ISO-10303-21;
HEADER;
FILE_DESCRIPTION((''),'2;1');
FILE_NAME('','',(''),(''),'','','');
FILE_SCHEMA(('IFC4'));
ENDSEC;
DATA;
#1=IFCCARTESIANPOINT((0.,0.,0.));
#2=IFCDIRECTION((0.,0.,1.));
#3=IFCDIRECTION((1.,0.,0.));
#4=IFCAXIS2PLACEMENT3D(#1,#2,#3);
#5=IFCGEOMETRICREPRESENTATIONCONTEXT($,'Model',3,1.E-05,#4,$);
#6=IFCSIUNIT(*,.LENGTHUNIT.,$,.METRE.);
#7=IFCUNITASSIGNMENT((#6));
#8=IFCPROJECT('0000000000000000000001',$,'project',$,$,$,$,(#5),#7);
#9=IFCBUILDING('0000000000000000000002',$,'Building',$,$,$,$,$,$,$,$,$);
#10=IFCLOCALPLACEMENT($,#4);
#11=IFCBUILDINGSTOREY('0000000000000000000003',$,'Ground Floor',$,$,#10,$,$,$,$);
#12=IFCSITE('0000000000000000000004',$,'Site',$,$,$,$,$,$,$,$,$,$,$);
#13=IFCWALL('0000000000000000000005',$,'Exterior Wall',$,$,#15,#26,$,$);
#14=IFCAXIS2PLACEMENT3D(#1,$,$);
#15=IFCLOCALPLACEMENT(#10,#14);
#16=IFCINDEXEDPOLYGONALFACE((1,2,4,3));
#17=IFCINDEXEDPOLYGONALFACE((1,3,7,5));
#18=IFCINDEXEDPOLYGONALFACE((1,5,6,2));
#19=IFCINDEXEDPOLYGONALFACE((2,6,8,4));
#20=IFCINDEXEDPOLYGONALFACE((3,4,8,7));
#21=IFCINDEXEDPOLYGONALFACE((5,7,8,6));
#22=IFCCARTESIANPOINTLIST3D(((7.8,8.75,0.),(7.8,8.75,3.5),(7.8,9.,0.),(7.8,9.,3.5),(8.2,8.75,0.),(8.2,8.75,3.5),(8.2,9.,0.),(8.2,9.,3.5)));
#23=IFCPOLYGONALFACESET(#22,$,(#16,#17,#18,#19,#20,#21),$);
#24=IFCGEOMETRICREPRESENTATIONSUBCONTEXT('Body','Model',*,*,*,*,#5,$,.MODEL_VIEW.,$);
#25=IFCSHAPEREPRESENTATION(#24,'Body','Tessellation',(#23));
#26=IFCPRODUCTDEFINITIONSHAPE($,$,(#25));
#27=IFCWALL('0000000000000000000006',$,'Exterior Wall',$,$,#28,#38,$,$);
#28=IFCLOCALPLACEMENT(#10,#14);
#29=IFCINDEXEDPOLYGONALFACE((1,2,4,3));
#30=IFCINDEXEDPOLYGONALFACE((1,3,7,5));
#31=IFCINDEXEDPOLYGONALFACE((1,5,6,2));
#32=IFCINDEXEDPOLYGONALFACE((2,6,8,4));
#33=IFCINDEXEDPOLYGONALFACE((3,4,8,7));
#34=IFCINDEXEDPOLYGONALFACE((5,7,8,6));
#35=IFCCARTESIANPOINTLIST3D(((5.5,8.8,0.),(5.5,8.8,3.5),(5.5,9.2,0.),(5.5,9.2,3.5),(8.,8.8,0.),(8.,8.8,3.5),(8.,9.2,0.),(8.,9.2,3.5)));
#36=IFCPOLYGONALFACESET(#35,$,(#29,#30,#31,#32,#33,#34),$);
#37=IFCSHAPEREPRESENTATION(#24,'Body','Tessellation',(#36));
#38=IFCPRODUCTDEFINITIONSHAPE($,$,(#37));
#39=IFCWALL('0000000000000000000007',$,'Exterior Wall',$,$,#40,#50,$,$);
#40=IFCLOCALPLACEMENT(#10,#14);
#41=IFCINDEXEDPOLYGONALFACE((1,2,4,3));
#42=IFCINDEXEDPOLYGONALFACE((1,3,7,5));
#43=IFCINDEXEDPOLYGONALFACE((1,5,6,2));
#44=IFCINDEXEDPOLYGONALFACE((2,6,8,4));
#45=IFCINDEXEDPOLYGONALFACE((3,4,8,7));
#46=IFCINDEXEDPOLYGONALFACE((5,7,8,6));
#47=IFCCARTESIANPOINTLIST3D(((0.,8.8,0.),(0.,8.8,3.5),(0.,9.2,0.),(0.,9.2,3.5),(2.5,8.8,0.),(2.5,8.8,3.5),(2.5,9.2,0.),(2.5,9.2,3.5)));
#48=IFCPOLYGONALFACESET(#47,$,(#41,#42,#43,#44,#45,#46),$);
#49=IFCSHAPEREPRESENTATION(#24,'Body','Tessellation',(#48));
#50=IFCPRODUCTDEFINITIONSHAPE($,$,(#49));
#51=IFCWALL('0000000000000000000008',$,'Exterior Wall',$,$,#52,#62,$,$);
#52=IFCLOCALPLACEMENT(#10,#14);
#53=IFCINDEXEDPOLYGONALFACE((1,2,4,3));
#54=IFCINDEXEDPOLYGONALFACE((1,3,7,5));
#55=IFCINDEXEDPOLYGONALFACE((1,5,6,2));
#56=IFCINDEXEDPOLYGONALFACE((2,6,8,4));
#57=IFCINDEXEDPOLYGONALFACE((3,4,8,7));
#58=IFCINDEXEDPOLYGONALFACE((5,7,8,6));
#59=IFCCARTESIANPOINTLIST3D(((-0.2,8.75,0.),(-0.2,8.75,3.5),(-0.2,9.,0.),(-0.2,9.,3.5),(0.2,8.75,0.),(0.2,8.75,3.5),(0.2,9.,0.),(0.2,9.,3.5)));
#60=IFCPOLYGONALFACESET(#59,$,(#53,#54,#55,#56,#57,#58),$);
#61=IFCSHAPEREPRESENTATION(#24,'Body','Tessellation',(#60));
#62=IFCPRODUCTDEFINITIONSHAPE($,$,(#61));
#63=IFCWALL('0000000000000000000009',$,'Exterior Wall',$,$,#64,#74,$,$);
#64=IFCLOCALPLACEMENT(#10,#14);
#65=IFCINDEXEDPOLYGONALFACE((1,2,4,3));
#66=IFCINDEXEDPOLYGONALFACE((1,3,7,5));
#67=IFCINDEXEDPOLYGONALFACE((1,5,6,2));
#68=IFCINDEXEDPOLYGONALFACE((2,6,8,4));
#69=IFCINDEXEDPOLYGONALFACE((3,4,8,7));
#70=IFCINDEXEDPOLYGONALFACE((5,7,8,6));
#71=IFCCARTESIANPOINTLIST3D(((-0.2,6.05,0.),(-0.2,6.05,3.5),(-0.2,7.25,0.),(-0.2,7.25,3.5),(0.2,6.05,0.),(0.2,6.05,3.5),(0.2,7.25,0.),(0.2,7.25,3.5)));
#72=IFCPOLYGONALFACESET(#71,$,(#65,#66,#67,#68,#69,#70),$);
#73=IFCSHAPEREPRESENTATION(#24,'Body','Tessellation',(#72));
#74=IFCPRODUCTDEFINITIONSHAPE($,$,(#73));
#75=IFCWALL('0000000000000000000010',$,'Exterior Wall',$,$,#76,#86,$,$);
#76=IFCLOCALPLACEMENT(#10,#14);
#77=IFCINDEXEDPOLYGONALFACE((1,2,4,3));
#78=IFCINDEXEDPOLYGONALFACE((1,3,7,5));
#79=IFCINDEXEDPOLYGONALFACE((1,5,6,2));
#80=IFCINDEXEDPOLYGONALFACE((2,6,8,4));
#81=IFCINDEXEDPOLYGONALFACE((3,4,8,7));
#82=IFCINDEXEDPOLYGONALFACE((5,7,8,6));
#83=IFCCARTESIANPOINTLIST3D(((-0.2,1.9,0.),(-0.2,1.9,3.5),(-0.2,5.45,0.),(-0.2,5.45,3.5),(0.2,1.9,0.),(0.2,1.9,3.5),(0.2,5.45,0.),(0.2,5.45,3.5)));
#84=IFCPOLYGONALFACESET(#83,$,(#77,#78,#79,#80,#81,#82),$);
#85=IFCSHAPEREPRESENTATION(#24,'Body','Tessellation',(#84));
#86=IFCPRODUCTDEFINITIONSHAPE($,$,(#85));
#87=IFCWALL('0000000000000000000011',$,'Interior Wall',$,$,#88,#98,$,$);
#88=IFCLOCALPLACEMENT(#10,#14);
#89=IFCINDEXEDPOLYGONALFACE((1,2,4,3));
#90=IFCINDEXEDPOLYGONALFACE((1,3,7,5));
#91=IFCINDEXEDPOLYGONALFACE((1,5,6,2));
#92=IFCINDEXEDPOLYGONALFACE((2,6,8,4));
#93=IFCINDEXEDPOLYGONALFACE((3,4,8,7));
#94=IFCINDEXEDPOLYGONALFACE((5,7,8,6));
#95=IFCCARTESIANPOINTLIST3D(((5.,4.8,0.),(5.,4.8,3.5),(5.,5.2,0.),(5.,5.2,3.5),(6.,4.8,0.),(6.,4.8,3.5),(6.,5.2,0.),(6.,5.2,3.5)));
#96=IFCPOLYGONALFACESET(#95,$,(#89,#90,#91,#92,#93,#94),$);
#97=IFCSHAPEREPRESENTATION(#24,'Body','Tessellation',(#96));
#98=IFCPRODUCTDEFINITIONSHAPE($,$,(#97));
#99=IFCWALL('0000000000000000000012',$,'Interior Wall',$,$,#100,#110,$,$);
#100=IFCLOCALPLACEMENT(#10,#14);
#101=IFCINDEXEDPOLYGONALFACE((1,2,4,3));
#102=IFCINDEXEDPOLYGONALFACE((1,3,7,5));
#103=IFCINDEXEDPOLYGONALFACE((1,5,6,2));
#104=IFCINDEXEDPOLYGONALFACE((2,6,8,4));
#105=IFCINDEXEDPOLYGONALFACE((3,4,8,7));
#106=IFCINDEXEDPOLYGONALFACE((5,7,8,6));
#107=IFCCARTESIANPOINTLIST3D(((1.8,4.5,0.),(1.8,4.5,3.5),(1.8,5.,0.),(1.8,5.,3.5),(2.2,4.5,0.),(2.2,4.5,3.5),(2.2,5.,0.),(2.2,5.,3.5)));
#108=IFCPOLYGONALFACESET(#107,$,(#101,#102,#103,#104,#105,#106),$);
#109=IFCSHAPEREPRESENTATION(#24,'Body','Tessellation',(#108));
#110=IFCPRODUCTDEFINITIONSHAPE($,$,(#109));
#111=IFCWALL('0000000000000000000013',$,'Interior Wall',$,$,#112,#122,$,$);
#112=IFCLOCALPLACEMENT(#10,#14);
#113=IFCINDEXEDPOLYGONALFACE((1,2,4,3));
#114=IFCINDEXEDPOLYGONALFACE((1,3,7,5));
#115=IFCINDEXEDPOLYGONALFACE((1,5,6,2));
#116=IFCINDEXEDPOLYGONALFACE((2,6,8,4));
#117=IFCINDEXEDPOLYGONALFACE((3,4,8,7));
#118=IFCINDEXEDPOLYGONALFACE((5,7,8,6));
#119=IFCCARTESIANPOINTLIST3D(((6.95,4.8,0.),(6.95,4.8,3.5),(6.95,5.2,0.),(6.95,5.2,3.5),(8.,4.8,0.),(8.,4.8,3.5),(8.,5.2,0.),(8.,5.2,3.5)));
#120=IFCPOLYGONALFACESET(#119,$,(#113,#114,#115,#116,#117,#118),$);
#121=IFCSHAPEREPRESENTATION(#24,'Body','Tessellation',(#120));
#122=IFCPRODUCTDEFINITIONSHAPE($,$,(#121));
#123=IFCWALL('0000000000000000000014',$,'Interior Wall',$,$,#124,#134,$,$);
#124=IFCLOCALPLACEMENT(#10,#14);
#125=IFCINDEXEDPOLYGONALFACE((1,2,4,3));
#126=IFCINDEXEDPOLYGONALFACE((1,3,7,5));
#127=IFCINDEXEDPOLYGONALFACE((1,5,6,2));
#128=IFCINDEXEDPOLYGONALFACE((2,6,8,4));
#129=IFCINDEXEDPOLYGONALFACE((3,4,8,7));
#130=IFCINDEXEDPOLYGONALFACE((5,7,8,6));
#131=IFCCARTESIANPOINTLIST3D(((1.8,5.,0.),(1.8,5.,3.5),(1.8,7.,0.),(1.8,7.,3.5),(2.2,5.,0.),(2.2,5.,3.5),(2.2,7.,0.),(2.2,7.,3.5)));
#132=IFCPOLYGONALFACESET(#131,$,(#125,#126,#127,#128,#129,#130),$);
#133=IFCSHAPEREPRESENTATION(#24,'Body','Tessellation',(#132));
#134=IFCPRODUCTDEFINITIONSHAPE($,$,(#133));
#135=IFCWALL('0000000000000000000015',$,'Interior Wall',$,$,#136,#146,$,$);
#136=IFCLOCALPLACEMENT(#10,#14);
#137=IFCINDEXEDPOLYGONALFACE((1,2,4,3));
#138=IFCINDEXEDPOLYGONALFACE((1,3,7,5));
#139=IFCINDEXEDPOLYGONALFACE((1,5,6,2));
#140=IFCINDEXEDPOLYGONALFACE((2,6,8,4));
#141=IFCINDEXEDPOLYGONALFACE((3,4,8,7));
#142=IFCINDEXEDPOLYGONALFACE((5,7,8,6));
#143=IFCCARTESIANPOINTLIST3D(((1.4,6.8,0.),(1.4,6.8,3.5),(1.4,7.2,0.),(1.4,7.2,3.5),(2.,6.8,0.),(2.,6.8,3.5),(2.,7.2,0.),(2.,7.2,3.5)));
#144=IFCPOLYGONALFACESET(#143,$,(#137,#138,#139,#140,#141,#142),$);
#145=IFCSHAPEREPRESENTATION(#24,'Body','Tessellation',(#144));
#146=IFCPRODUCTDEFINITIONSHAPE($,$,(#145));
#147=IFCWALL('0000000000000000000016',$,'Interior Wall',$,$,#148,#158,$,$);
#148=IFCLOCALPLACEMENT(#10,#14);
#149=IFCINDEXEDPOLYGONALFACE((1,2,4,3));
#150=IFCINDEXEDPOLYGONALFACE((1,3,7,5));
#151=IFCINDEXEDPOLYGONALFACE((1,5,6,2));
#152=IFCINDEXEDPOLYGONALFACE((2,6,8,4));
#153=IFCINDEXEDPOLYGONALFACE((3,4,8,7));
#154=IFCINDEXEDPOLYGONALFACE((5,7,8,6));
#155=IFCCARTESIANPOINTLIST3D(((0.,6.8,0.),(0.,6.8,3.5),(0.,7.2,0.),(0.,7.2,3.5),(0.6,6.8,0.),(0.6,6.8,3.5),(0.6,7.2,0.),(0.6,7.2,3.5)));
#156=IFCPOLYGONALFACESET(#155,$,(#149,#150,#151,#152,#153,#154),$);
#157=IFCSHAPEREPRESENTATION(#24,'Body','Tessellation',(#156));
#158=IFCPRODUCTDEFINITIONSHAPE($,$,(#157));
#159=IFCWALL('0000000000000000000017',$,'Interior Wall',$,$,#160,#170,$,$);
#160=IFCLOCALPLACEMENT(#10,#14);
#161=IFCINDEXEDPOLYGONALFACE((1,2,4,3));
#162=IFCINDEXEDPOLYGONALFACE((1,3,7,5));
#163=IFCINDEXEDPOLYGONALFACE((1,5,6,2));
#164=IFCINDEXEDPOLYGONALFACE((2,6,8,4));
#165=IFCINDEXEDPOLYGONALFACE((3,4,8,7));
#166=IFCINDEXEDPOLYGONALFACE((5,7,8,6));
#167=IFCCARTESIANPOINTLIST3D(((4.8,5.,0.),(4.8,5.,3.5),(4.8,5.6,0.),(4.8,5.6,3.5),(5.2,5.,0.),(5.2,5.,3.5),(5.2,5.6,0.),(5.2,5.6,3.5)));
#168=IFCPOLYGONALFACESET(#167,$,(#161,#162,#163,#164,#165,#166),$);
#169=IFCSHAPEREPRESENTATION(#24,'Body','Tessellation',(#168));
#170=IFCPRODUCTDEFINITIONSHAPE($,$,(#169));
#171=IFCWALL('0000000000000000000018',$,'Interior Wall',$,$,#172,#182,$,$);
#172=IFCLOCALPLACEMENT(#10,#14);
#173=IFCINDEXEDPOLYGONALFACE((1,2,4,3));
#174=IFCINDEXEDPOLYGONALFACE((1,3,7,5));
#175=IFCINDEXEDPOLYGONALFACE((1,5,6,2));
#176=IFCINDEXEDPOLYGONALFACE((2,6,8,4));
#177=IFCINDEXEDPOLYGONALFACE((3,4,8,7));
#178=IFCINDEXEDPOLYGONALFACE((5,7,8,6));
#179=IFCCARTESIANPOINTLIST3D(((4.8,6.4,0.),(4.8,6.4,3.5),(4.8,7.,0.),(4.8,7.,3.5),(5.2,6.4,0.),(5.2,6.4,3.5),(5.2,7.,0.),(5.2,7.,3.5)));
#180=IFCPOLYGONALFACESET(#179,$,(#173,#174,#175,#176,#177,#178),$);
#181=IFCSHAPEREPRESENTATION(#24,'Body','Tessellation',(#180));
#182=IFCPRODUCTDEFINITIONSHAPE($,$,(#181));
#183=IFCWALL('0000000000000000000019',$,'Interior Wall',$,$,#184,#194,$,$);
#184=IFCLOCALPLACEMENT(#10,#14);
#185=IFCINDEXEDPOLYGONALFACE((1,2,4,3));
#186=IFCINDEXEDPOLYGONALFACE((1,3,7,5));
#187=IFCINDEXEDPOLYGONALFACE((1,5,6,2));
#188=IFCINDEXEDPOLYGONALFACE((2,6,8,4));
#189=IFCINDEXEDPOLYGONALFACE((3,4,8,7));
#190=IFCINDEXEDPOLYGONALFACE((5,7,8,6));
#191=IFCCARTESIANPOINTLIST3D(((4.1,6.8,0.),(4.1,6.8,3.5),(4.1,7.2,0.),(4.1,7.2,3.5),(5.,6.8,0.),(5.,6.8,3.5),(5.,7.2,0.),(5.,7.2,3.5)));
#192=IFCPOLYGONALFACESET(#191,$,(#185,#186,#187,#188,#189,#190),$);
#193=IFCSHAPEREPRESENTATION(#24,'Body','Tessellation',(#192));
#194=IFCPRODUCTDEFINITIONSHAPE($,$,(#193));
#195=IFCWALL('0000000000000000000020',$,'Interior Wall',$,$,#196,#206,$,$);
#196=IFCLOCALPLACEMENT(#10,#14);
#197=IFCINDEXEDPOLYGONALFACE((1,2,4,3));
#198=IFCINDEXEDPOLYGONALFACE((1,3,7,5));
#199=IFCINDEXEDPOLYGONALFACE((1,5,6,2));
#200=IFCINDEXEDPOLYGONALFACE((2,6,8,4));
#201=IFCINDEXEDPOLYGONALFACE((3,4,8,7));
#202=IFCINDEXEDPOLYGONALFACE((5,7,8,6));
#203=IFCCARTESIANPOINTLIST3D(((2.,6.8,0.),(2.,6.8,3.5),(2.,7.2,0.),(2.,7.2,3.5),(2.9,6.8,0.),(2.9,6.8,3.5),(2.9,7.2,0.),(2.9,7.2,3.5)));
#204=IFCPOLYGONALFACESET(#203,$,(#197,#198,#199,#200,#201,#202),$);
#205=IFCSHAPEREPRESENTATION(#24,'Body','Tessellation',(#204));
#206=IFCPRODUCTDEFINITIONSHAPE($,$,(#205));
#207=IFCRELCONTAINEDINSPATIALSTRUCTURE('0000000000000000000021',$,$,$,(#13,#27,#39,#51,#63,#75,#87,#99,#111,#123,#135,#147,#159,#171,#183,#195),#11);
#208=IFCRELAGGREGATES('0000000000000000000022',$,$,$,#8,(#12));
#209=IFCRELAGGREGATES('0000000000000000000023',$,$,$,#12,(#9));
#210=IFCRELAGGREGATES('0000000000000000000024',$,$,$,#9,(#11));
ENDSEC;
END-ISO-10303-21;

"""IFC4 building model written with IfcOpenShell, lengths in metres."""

from ifc_helpers import new_model, si_unit, frame, origin_with_axes, place, context, subcontext, project, spatial, indexed_curve, outline, extrude, element, save


model = new_model("IFC4")

# Units and contexts
model_context = context("Model", 3, precision=1e-05, world=origin_with_axes())
body_context = subcontext(model_context, "Body", "Model", "MODEL_VIEW")
ifc_project = project(units=[si_unit("LENGTHUNIT", "METRE")], contexts=[model_context])

# Site, building, storey
site = spatial("IfcSite", under=ifc_project, Name="Site")
building = spatial("IfcBuilding", under=site, Name="Building")
storey_placement = place(None, origin_with_axes())
storey = spatial("IfcBuildingStorey", under=building, at=storey_placement, Name="Ground Floor")

# Walls
wall_1_placement = place(storey_placement, frame((8.0, 8.75, 0.0), z_axis=(0.0, 0.0, 1.0), x_axis=(0.0, 1.0, 0.0)))
element("IfcWall", 1, at=wall_1_placement, inside=storey, Name="Exterior Wall", context=body_context, shape_type="SweptSolid", body=[
    extrude(outline(indexed_curve([(0.0, 0.0), (0.0, 0.4), (0.25, 0.4), (0.25, 0.0), (0.0, 0.0)], self_intersect=False)), frame((0.0, -0.2, 0.0), z_axis=(0.0, 0.0, 1.0), x_axis=(1.0, 0.0, 0.0)), (0.0, 0.0, 1.0), 3.5),
])
for number, where, z_axis, x_axis, name in (
    (2, (8.0, 9.0, 0.0), (0.0, 0.0, 1.0), (-1.0, 0.0, 0.0), "Exterior Wall"),
    (3, (2.5, 9.0, 0.0), (0.0, 0.0, 1.0), (-1.0, 0.0, 0.0), "Exterior Wall"),
):
    element("IfcWall", number, at=place(storey_placement, frame(where, z_axis=z_axis, x_axis=x_axis)), inside=storey, Name=name, context=body_context, shape_type="SweptSolid", body=[
        extrude(outline(indexed_curve([(0.0, 0.0), (0.0, 0.4), (2.5, 0.4), (2.5, 0.0), (0.0, 0.0)], self_intersect=False)), frame((0.0, -0.2, 0.0), z_axis=(0.0, 0.0, 1.0), x_axis=(1.0, 0.0, 0.0)), (0.0, 0.0, 1.0), 3.5),
    ])
wall_2_placement = place(storey_placement, frame((0.0, 9.0, 0.0), z_axis=(0.0, 0.0, 1.0), x_axis=(0.0, -1.0, 0.0)))
element("IfcWall", 4, at=wall_2_placement, inside=storey, Name="Exterior Wall", context=body_context, shape_type="SweptSolid", body=[
    extrude(outline(indexed_curve([(0.0, 0.0), (0.0, 0.4), (0.25, 0.4), (0.25, 0.0), (0.0, 0.0)], self_intersect=False)), frame((0.0, -0.2, 0.0), z_axis=(0.0, 0.0, 1.0), x_axis=(1.0, 0.0, 0.0)), (0.0, 0.0, 1.0), 3.5),
])
wall_3_placement = place(storey_placement, frame((0.0, 7.25, 0.0), z_axis=(0.0, 0.0, 1.0), x_axis=(0.0, -1.0, 0.0)))
element("IfcWall", 5, at=wall_3_placement, inside=storey, Name="Exterior Wall", context=body_context, shape_type="SweptSolid", body=[
    extrude(outline(indexed_curve([(0.0, 0.0), (0.0, 0.4), (1.2, 0.4), (1.2, 0.0), (0.0, 0.0)], self_intersect=False)), frame((0.0, -0.2, 0.0), z_axis=(0.0, 0.0, 1.0), x_axis=(1.0, 0.0, 0.0)), (0.0, 0.0, 1.0), 3.5),
])
wall_4_placement = place(storey_placement, frame((0.0, 5.45, 0.0), z_axis=(0.0, 0.0, 1.0), x_axis=(0.0, -1.0, 0.0)))
element("IfcWall", 6, at=wall_4_placement, inside=storey, Name="Exterior Wall", context=body_context, shape_type="SweptSolid", body=[
    extrude(outline(indexed_curve([(0.0, 0.0), (0.0, 0.4), (3.55, 0.4), (3.55, 0.0), (0.0, 0.0)], self_intersect=False)), frame((0.0, -0.2, 0.0), z_axis=(0.0, 0.0, 1.0), x_axis=(1.0, 0.0, 0.0)), (0.0, 0.0, 1.0), 3.5),
])
wall_5_placement = place(storey_placement, frame((6.0, 5.0, 0.0), z_axis=(0.0, 0.0, 1.0), x_axis=(-1.0, 0.0, 0.0)))
element("IfcWall", 7, at=wall_5_placement, inside=storey, Name="Interior Wall", context=body_context, shape_type="SweptSolid", body=[
    extrude(outline(indexed_curve([(0.0, 0.0), (0.0, 0.4), (1.0, 0.4), (1.0, 0.0), (0.0, 0.0)], self_intersect=False)), frame((0.0, -0.2, 0.0), z_axis=(0.0, 0.0, 1.0), x_axis=(1.0, 0.0, 0.0)), (0.0, 0.0, 1.0), 3.5),
])
wall_6_placement = place(storey_placement, frame((2.0, 5.0, 0.0), z_axis=(0.0, 0.0, 1.0), x_axis=(0.0, -1.0, 0.0)))
element("IfcWall", 8, at=wall_6_placement, inside=storey, Name="Interior Wall", context=body_context, shape_type="SweptSolid", body=[
    extrude(outline(indexed_curve([(0.0, 0.0), (0.0, 0.4), (0.5, 0.4), (0.5, 0.0), (0.0, 0.0)], self_intersect=False)), frame((0.0, -0.2, 0.0), z_axis=(0.0, 0.0, 1.0), x_axis=(1.0, 0.0, 0.0)), (0.0, 0.0, 1.0), 3.5),
])
wall_7_placement = place(storey_placement, frame((8.0, 5.0, 0.0), z_axis=(0.0, 0.0, 1.0), x_axis=(-1.0, 0.0, 0.0)))
element("IfcWall", 9, at=wall_7_placement, inside=storey, Name="Interior Wall", context=body_context, shape_type="SweptSolid", body=[
    extrude(outline(indexed_curve([(0.0, 0.0), (0.0, 0.4), (1.05, 0.4), (1.05, 0.0), (0.0, 0.0)], self_intersect=False)), frame((0.0, -0.2, 0.0), z_axis=(0.0, 0.0, 1.0), x_axis=(1.0, 0.0, 0.0)), (0.0, 0.0, 1.0), 3.5),
])
wall_8_placement = place(storey_placement, frame((2.0, 5.0, 0.0), z_axis=(0.0, 0.0, 1.0), x_axis=(0.0, 1.0, 0.0)))
element("IfcWall", 10, at=wall_8_placement, inside=storey, Name="Interior Wall", context=body_context, shape_type="SweptSolid", body=[
    extrude(outline(indexed_curve([(0.0, 0.0), (0.0, 0.4), (2.0, 0.4), (2.0, 0.0), (0.0, 0.0)], self_intersect=False)), frame((0.0, -0.2, 0.0), z_axis=(0.0, 0.0, 1.0), x_axis=(1.0, 0.0, 0.0)), (0.0, 0.0, 1.0), 3.5),
])
for number, where, z_axis, x_axis, name in (
    (11, (2.0, 7.0, 0.0), (0.0, 0.0, 1.0), (-1.0, 0.0, 0.0), "Interior Wall"),
    (12, (0.6, 7.0, 0.0), (0.0, 0.0, 1.0), (-1.0, 0.0, 0.0), "Interior Wall"),
):
    element("IfcWall", number, at=place(storey_placement, frame(where, z_axis=z_axis, x_axis=x_axis)), inside=storey, Name=name, context=body_context, shape_type="SweptSolid", body=[
        extrude(outline(indexed_curve([(0.0, 0.0), (0.0, 0.4), (0.6, 0.4), (0.6, 0.0), (0.0, 0.0)], self_intersect=False)), frame((0.0, -0.2, 0.0), z_axis=(0.0, 0.0, 1.0), x_axis=(1.0, 0.0, 0.0)), (0.0, 0.0, 1.0), 3.5),
    ])
for number, where, z_axis, x_axis, name in (
    (13, (5.0, 5.0, 0.0), (0.0, 0.0, 1.0), (0.0, 1.0, 0.0), "Interior Wall"),
    (14, (5.0, 6.4, 0.0), (0.0, 0.0, 1.0), (0.0, 1.0, 0.0), "Interior Wall"),
):
    element("IfcWall", number, at=place(storey_placement, frame(where, z_axis=z_axis, x_axis=x_axis)), inside=storey, Name=name, context=body_context, shape_type="SweptSolid", body=[
        extrude(outline(indexed_curve([(0.0, 0.0), (0.0, 0.4), (0.6, 0.4), (0.6, 0.0), (0.0, 0.0)], self_intersect=False)), frame((0.0, -0.2, 0.0), z_axis=(0.0, 0.0, 1.0), x_axis=(1.0, 0.0, 0.0)), (0.0, 0.0, 1.0), 3.5),
    ])
wall_9_placement = place(storey_placement, frame((5.0, 7.0, 0.0), z_axis=(0.0, 0.0, 1.0), x_axis=(-1.0, 0.0, 0.0)))
element("IfcWall", 15, at=wall_9_placement, inside=storey, Name="Interior Wall", context=body_context, shape_type="SweptSolid", body=[
    extrude(outline(indexed_curve([(0.0, 0.0), (0.0, 0.4), (0.9, 0.4), (0.9, 0.0), (0.0, 0.0)], self_intersect=False)), frame((0.0, -0.2, 0.0), z_axis=(0.0, 0.0, 1.0), x_axis=(1.0, 0.0, 0.0)), (0.0, 0.0, 1.0), 3.5),
])
wall_10_placement = place(storey_placement, frame((2.9, 7.0, 0.0), z_axis=(0.0, 0.0, 1.0), x_axis=(-1.0, 0.0, 0.0)))
element("IfcWall", 16, at=wall_10_placement, inside=storey, Name="Interior Wall", context=body_context, shape_type="SweptSolid", body=[
    extrude(outline(indexed_curve([(0.0, 0.0), (0.0, 0.4), (0.9, 0.4), (0.9, 0.0), (0.0, 0.0)], self_intersect=False)), frame((0.0, -0.2, 0.0), z_axis=(0.0, 0.0, 1.0), x_axis=(1.0, 0.0, 0.0)), (0.0, 0.0, 1.0), 3.5),
])

save(model, "model.ifc")
